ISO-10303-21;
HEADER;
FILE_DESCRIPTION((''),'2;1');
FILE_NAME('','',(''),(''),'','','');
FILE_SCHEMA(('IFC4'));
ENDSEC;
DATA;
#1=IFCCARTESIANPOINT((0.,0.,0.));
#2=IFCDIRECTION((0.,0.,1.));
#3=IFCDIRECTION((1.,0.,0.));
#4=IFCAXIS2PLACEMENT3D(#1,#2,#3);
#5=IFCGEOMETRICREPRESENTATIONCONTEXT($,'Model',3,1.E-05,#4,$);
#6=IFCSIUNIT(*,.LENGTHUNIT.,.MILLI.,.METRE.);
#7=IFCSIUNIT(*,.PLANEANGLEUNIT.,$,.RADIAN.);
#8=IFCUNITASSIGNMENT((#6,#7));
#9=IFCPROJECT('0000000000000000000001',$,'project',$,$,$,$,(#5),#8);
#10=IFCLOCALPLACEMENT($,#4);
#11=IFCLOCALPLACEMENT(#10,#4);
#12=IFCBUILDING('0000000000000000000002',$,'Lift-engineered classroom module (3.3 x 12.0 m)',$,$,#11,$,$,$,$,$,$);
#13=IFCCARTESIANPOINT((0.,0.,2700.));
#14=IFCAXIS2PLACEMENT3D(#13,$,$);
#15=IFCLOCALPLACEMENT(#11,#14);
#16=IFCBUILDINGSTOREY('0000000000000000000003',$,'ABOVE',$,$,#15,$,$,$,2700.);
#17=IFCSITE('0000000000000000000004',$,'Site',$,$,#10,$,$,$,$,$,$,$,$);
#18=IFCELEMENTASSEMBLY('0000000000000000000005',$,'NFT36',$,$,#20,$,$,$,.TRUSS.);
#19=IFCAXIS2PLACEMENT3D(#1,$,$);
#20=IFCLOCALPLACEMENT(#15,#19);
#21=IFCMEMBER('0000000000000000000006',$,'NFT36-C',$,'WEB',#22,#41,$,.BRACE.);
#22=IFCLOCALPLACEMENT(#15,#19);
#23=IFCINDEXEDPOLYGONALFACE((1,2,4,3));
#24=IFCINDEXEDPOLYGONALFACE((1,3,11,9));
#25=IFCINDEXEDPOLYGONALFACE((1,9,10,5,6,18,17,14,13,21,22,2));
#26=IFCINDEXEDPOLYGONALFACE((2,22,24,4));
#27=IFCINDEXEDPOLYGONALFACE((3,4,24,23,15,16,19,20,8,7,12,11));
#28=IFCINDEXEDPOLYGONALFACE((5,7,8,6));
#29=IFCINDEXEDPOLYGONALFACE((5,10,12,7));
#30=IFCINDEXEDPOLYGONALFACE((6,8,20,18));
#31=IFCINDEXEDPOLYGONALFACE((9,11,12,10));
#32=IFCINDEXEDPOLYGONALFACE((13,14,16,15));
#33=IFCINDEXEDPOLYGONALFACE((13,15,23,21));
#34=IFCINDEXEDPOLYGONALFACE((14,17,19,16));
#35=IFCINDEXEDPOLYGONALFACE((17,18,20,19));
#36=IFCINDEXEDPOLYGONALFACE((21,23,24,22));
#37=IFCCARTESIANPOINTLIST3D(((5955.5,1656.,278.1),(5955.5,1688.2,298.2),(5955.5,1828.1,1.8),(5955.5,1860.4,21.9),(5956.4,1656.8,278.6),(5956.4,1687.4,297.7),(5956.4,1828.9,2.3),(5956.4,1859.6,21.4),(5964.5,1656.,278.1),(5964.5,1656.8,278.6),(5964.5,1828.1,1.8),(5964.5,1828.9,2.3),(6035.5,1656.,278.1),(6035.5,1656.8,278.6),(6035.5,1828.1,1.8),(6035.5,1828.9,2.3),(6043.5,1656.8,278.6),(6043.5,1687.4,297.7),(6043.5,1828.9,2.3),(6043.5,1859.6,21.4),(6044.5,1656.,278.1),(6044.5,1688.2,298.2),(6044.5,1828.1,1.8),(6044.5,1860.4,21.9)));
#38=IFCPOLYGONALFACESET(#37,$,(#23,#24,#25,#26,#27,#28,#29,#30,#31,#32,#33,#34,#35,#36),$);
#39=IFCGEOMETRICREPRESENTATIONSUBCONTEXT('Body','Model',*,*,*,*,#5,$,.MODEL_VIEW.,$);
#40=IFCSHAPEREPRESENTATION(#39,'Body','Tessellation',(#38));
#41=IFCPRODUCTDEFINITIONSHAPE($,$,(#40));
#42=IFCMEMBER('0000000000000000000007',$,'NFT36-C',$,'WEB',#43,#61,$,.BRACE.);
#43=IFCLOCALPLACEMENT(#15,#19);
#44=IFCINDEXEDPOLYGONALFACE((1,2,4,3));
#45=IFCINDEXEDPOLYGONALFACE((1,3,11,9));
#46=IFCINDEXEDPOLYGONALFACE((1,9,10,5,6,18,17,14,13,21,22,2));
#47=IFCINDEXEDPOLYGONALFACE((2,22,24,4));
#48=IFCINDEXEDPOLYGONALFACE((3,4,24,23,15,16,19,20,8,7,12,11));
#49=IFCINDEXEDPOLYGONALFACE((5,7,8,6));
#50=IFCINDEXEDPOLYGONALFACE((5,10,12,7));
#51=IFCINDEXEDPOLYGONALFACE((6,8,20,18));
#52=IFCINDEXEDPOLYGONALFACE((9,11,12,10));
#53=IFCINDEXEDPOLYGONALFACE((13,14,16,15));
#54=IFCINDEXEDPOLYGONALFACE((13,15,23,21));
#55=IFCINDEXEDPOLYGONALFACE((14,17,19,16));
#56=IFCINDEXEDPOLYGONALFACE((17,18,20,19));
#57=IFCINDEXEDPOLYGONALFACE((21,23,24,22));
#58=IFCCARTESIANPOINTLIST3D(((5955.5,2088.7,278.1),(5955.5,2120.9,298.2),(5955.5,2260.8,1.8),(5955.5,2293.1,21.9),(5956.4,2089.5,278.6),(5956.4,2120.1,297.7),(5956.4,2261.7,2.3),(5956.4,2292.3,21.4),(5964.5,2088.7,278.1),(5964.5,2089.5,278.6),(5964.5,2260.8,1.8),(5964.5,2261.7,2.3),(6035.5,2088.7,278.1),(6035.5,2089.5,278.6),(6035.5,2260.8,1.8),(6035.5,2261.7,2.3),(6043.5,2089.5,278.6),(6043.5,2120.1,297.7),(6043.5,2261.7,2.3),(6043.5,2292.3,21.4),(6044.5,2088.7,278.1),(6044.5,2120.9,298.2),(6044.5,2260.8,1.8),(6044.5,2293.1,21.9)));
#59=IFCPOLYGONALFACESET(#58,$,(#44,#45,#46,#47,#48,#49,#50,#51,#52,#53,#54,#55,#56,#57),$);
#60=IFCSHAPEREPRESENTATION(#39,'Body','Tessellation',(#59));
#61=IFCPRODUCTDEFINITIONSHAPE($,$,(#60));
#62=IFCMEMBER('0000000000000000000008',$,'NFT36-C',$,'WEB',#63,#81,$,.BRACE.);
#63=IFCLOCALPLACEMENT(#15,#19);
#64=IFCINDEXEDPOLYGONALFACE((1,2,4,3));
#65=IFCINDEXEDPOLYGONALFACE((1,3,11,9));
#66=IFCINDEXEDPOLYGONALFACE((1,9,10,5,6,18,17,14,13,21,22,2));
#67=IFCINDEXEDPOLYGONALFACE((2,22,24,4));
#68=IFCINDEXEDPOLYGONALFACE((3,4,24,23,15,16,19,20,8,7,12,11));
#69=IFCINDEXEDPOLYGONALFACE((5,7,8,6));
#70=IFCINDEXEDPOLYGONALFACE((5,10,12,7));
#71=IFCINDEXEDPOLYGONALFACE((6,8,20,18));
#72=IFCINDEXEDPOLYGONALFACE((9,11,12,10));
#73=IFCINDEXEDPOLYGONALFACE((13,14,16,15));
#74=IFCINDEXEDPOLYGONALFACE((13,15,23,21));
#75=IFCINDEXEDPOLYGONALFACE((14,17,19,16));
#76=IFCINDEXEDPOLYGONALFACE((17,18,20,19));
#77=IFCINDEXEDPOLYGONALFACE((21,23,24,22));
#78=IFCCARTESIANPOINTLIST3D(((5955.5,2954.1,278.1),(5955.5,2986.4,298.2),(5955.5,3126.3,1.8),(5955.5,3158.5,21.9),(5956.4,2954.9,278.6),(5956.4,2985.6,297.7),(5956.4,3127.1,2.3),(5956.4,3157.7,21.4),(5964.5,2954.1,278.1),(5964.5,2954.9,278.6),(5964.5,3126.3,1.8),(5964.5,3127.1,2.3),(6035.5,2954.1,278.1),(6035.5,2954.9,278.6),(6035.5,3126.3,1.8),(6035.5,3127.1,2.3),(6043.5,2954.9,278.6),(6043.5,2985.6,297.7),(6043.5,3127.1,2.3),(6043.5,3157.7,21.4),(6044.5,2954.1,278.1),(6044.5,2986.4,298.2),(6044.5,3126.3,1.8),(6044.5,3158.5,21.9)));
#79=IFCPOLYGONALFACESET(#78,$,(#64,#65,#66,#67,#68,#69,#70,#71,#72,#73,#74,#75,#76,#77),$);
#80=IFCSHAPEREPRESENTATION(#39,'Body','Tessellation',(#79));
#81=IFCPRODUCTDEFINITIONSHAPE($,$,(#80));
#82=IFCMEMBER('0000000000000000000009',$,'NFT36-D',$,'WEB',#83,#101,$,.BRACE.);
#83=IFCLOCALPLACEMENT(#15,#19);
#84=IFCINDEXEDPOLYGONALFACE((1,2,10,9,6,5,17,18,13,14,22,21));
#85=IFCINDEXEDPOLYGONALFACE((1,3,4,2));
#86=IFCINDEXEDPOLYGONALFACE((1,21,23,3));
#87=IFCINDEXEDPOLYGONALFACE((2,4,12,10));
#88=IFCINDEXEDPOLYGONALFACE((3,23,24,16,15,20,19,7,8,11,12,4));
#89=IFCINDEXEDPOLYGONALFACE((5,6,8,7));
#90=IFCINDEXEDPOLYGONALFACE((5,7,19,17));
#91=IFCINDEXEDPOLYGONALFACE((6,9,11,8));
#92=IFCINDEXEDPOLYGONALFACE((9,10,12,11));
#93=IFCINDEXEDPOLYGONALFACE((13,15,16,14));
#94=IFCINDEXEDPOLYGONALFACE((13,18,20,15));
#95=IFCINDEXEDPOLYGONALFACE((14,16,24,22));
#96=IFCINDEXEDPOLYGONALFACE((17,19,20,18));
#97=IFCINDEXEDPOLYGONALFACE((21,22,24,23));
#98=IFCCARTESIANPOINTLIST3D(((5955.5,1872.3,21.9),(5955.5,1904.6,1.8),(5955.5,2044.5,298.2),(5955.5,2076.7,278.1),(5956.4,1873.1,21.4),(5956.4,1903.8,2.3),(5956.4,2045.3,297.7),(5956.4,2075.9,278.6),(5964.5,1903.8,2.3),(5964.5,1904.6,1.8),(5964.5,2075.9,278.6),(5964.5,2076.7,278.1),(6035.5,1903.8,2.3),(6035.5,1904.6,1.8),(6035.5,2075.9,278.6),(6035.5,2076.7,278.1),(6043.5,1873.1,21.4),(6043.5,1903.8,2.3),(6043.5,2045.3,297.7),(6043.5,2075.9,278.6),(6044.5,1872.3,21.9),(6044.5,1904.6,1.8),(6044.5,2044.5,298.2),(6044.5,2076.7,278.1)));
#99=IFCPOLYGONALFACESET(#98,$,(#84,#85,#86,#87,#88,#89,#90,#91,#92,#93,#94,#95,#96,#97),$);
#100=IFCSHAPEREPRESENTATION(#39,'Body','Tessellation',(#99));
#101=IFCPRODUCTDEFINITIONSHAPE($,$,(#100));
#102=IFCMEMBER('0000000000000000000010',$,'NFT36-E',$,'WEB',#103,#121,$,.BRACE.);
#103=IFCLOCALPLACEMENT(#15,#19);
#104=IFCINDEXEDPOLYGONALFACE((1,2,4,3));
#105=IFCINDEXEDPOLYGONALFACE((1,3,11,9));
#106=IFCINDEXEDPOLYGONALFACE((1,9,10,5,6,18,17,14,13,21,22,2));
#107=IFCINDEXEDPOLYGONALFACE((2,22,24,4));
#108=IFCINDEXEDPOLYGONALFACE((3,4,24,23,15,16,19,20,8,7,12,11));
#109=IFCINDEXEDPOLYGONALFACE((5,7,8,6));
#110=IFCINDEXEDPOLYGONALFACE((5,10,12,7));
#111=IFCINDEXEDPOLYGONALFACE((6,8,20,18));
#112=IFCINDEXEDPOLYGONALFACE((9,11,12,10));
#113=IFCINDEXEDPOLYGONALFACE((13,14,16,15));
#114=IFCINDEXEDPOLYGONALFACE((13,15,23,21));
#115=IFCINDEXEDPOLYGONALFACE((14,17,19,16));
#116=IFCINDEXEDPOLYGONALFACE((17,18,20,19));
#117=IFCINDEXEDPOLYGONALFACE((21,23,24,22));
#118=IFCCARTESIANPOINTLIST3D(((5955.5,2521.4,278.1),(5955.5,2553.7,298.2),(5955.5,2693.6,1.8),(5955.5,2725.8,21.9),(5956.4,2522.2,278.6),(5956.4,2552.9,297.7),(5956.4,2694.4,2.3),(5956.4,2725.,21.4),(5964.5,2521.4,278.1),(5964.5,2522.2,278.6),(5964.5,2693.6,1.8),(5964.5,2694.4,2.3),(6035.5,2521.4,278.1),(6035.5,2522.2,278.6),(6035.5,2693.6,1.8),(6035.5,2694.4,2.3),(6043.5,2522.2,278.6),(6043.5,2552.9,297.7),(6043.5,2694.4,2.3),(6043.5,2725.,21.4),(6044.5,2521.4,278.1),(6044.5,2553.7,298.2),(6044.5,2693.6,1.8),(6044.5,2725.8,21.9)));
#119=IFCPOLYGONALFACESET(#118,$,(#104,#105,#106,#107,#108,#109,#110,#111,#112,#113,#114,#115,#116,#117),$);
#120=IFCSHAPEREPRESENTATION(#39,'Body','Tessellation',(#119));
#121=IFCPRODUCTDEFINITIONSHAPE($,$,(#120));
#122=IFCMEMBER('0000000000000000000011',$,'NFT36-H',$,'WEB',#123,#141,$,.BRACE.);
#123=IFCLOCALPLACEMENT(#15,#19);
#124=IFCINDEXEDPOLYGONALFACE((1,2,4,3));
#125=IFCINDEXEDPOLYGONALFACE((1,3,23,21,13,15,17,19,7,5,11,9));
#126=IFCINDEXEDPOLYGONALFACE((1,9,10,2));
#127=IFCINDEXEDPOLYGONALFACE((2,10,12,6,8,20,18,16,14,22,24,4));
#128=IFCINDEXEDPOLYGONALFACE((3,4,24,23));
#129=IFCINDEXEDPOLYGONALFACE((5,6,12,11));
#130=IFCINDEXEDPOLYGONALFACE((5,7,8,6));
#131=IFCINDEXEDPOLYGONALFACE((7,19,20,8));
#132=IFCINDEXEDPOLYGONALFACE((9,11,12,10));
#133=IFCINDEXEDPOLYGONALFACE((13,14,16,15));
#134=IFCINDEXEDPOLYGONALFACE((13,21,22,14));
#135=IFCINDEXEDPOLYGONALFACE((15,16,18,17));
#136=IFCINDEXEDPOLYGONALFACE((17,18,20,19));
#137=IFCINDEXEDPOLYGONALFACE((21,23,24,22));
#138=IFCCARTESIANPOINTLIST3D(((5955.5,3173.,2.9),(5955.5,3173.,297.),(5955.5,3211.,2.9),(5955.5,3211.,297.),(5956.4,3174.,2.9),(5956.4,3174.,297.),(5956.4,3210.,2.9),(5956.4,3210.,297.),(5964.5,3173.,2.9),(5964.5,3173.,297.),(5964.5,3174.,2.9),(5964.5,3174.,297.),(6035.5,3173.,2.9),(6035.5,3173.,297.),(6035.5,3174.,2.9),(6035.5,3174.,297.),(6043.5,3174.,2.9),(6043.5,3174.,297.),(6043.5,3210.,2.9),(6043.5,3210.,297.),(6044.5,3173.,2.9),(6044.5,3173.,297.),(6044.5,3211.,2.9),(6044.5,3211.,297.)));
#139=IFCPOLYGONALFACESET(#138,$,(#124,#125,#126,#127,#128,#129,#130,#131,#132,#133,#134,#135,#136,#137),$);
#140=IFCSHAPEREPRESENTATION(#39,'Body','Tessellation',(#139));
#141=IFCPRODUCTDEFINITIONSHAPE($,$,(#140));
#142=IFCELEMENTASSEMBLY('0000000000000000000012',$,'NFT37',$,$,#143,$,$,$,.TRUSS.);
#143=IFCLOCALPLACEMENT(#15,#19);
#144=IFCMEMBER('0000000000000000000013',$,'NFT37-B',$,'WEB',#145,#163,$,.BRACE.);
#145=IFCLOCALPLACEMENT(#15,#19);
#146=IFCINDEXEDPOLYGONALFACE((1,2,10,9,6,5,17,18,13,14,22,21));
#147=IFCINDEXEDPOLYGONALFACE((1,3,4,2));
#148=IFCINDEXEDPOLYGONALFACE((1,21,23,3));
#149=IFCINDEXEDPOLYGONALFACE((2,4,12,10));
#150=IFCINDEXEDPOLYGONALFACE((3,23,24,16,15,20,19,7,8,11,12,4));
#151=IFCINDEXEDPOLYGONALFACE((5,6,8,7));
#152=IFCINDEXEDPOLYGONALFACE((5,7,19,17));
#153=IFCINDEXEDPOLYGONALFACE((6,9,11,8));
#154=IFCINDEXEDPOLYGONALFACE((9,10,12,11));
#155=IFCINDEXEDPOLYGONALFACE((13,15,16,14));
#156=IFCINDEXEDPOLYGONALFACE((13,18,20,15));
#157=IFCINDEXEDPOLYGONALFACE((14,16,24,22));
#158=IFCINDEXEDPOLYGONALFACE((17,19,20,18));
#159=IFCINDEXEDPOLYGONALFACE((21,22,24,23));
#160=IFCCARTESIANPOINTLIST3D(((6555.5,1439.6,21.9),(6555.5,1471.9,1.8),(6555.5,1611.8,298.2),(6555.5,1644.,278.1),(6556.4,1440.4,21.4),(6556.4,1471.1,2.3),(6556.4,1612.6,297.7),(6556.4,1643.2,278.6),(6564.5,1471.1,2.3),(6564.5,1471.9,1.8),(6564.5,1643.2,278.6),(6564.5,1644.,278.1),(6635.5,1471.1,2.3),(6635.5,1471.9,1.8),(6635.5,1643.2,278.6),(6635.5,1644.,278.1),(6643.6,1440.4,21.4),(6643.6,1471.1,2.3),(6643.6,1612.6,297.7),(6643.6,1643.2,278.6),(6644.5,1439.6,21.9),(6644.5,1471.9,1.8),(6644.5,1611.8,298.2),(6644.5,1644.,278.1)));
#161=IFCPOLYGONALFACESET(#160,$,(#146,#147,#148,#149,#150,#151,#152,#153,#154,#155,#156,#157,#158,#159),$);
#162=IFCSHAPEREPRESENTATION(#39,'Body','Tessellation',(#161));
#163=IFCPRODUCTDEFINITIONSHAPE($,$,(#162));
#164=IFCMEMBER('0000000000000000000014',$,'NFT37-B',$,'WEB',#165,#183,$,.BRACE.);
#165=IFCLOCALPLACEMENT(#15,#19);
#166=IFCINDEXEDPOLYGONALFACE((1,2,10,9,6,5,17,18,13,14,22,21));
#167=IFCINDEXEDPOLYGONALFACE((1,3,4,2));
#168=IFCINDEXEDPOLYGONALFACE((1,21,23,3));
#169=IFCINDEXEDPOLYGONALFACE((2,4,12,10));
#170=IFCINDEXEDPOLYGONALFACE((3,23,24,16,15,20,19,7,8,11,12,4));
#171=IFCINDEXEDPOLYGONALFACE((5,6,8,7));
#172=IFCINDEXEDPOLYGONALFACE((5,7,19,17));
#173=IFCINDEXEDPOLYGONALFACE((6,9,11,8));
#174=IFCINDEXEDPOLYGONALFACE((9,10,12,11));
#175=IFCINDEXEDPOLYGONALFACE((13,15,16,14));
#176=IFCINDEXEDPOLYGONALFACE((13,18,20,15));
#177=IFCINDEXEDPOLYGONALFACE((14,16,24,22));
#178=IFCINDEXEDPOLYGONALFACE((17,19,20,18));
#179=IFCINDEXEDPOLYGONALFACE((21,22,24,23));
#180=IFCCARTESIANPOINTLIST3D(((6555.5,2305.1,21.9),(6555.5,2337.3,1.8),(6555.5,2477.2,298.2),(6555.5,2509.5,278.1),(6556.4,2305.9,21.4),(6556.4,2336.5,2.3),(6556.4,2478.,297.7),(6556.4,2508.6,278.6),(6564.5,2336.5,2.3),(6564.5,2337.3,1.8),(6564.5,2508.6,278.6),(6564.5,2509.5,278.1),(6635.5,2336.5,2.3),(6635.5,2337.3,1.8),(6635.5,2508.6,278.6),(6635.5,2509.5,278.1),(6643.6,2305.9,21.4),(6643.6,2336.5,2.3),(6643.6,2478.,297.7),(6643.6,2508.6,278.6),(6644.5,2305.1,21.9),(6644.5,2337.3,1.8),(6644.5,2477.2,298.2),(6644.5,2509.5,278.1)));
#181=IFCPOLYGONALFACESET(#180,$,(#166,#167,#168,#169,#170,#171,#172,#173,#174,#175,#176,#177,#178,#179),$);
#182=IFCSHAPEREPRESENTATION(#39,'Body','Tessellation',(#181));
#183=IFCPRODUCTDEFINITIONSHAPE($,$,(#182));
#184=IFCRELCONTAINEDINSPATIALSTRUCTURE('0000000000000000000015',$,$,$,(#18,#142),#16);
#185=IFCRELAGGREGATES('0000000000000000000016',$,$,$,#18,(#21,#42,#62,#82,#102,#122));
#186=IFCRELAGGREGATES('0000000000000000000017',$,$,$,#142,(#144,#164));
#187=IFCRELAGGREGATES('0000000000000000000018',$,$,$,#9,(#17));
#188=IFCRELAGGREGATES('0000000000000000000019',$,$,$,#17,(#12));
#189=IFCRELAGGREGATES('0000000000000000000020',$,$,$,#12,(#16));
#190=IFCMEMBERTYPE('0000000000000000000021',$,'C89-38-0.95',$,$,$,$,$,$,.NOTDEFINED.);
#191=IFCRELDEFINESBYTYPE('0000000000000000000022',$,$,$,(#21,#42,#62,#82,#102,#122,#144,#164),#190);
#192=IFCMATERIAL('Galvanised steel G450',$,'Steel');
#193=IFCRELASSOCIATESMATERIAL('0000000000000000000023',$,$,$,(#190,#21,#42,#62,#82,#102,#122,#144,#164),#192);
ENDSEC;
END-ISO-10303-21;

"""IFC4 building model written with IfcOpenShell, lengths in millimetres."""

from ifc_helpers import new_model, si_unit, frame, origin, origin_with_axes, origin_2d, place, context, subcontext, project, spatial, c_section, extrude, material, material_profile, profile_set, profile_usage, type_object, element, aggregate, save


model = new_model("IFC4")

# Units and contexts
model_context = context("Model", 3, precision=1e-05, world=origin_with_axes())
body_context = subcontext(model_context, "Body", "Model", "MODEL_VIEW")
ifc_project = project(units=[si_unit("LENGTHUNIT", "METRE", prefix="MILLI"), si_unit("PLANEANGLEUNIT", "RADIAN")], contexts=[model_context])

# Site, building, storey
site_placement = place(None, origin_with_axes())
site = spatial("IfcSite", under=ifc_project, at=site_placement, Name="Site")
building_placement = place(site_placement, origin_with_axes())
building = spatial("IfcBuilding", under=site, at=building_placement, Name="Lift-engineered classroom module (3.3 x 12.0 m)")
storey_placement = place(building_placement, frame((0.0, 0.0, 2700.0)))
storey = spatial("IfcBuildingStorey", under=building, at=storey_placement, Name="ABOVE", Elevation=2700.0)

# Element assemblies, members
assembly_1_placement = place(storey_placement, frame((6000.0, 89.0, 0.0)))
assembly_1 = element("IfcElementAssembly", 1, at=assembly_1_placement, inside=storey, Name="NFT36", PredefinedType="TRUSS")
ifc_material = material(Name="Galvanised steel G450", Category="Steel")
ifc_material_profile_1 = material_profile(ifc_material, c_section(Depth=89.0, Width=38.0, WallThickness=0.9, Girth=9.0, at=origin_2d()), Name="C89-38-0.95")
ifc_profile_set_1 = profile_set([ifc_material_profile_1], Name="C89-38-0.95")
ifc_profile_usage_1 = profile_usage(ifc_profile_set_1)
member_type_1 = type_object("IfcMemberType", Name="C89-38-0.95", PredefinedType="NOTDEFINED", material=ifc_profile_set_1)
member_1_placement = place(assembly_1_placement, frame((0.0, 1755.3, 11.8), z_axis=(0.0, -0.528797, 0.848748), x_axis=(0.0, -0.848748, -0.528797)))
member_1 = element("IfcMember", 2, at=member_1_placement, type_object=member_type_1, material=ifc_profile_usage_1, Name="NFT36-C", ObjectType="WEB", PredefinedType="BRACE", context=body_context, shape_type="SweptSolid", body=[
    extrude(c_section(Depth=89.0, Width=38.0, WallThickness=0.9, Girth=9.0, at=origin_2d()), origin(), (0.0, 0.0, 1.0), 325.6),
])
member_2_placement = place(assembly_1_placement, frame((0.0, 2188.0, 11.8), z_axis=(0.0, -0.528797, 0.848748), x_axis=(0.0, -0.848748, -0.528797)))
member_2 = element("IfcMember", 3, at=member_2_placement, type_object=member_type_1, material=ifc_profile_usage_1, Name="NFT36-C", ObjectType="WEB", PredefinedType="BRACE", context=body_context, shape_type="SweptSolid", body=[
    extrude(c_section(Depth=89.0, Width=38.0, WallThickness=0.9, Girth=9.0, at=origin_2d()), origin(), (0.0, 0.0, 1.0), 325.6),
])
member_3_placement = place(assembly_1_placement, frame((0.0, 3053.4, 11.8), z_axis=(0.0, -0.528797, 0.848748), x_axis=(0.0, -0.848748, -0.528797)))
member_3 = element("IfcMember", 4, at=member_3_placement, type_object=member_type_1, material=ifc_profile_usage_1, Name="NFT36-C", ObjectType="WEB", PredefinedType="BRACE", context=body_context, shape_type="SweptSolid", body=[
    extrude(c_section(Depth=89.0, Width=38.0, WallThickness=0.9, Girth=9.0, at=origin_2d()), origin(), (0.0, 0.0, 1.0), 325.6),
])
member_4_placement = place(assembly_1_placement, frame((0.0, 1799.5, 11.8), z_axis=(0.0, 0.528775, 0.848762), x_axis=(0.0, 0.848762, -0.528775)))
member_4 = element("IfcMember", 5, at=member_4_placement, type_object=member_type_1, material=ifc_profile_usage_1, Name="NFT36-D", ObjectType="WEB", PredefinedType="BRACE", context=body_context, shape_type="SweptSolid", body=[
    extrude(c_section(Depth=89.0, Width=38.0, WallThickness=0.9, Girth=9.0, at=origin_2d()), origin(), (0.0, 0.0, 1.0), 325.6),
])
member_5_placement = place(assembly_1_placement, frame((0.0, 2620.7, 11.8), z_axis=(0.0, -0.528775, 0.848762), x_axis=(0.0, -0.848762, -0.528775)))
member_5 = element("IfcMember", 6, at=member_5_placement, type_object=member_type_1, material=ifc_profile_usage_1, Name="NFT36-E", ObjectType="WEB", PredefinedType="BRACE", context=body_context, shape_type="SweptSolid", body=[
    extrude(c_section(Depth=89.0, Width=38.0, WallThickness=0.9, Girth=9.0, at=origin_2d()), origin(), (0.0, 0.0, 1.0), 325.6),
])
member_6_placement = place(assembly_1_placement, frame((0.0, 3103.0, 2.9), z_axis=(0.0, 0.0, 1.0), x_axis=(0.0, -1.0, 0.0)))
member_6 = element("IfcMember", 7, at=member_6_placement, type_object=member_type_1, material=ifc_profile_usage_1, Name="NFT36-H", ObjectType="WEB", PredefinedType="BRACE", context=body_context, shape_type="SweptSolid", body=[
    extrude(c_section(Depth=89.0, Width=38.0, WallThickness=0.9, Girth=9.0, at=origin_2d()), origin(), (0.0, 0.0, 1.0), 294.1),
])
aggregate(assembly_1, [member_1, member_2, member_3, member_4, member_5, member_6])
assembly_2_placement = place(storey_placement, frame((6600.0, 89.0, 0.0)))
assembly_2 = element("IfcElementAssembly", 8, at=assembly_2_placement, inside=storey, Name="NFT37", PredefinedType="TRUSS")
member_7_placement = place(assembly_2_placement, frame((0.0, 1366.7, 11.8), z_axis=(0.0, 0.528797, 0.848748), x_axis=(0.0, 0.848748, -0.528797)))
member_7 = element("IfcMember", 9, at=member_7_placement, type_object=member_type_1, material=ifc_profile_usage_1, Name="NFT37-B", ObjectType="WEB", PredefinedType="BRACE", context=body_context, shape_type="SweptSolid", body=[
    extrude(c_section(Depth=89.0, Width=38.0, WallThickness=0.9, Girth=9.0, at=origin_2d()), origin(), (0.0, 0.0, 1.0), 325.6),
])
member_8_placement = place(assembly_2_placement, frame((0.0, 2232.2, 11.8), z_axis=(0.0, 0.528797, 0.848748), x_axis=(0.0, 0.848748, -0.528797)))
member_8 = element("IfcMember", 10, at=member_8_placement, type_object=member_type_1, material=ifc_profile_usage_1, Name="NFT37-B", ObjectType="WEB", PredefinedType="BRACE", context=body_context, shape_type="SweptSolid", body=[
    extrude(c_section(Depth=89.0, Width=38.0, WallThickness=0.9, Girth=9.0, at=origin_2d()), origin(), (0.0, 0.0, 1.0), 325.6),
])
aggregate(assembly_2, [member_7, member_8])

save(model, "model.ifc")
